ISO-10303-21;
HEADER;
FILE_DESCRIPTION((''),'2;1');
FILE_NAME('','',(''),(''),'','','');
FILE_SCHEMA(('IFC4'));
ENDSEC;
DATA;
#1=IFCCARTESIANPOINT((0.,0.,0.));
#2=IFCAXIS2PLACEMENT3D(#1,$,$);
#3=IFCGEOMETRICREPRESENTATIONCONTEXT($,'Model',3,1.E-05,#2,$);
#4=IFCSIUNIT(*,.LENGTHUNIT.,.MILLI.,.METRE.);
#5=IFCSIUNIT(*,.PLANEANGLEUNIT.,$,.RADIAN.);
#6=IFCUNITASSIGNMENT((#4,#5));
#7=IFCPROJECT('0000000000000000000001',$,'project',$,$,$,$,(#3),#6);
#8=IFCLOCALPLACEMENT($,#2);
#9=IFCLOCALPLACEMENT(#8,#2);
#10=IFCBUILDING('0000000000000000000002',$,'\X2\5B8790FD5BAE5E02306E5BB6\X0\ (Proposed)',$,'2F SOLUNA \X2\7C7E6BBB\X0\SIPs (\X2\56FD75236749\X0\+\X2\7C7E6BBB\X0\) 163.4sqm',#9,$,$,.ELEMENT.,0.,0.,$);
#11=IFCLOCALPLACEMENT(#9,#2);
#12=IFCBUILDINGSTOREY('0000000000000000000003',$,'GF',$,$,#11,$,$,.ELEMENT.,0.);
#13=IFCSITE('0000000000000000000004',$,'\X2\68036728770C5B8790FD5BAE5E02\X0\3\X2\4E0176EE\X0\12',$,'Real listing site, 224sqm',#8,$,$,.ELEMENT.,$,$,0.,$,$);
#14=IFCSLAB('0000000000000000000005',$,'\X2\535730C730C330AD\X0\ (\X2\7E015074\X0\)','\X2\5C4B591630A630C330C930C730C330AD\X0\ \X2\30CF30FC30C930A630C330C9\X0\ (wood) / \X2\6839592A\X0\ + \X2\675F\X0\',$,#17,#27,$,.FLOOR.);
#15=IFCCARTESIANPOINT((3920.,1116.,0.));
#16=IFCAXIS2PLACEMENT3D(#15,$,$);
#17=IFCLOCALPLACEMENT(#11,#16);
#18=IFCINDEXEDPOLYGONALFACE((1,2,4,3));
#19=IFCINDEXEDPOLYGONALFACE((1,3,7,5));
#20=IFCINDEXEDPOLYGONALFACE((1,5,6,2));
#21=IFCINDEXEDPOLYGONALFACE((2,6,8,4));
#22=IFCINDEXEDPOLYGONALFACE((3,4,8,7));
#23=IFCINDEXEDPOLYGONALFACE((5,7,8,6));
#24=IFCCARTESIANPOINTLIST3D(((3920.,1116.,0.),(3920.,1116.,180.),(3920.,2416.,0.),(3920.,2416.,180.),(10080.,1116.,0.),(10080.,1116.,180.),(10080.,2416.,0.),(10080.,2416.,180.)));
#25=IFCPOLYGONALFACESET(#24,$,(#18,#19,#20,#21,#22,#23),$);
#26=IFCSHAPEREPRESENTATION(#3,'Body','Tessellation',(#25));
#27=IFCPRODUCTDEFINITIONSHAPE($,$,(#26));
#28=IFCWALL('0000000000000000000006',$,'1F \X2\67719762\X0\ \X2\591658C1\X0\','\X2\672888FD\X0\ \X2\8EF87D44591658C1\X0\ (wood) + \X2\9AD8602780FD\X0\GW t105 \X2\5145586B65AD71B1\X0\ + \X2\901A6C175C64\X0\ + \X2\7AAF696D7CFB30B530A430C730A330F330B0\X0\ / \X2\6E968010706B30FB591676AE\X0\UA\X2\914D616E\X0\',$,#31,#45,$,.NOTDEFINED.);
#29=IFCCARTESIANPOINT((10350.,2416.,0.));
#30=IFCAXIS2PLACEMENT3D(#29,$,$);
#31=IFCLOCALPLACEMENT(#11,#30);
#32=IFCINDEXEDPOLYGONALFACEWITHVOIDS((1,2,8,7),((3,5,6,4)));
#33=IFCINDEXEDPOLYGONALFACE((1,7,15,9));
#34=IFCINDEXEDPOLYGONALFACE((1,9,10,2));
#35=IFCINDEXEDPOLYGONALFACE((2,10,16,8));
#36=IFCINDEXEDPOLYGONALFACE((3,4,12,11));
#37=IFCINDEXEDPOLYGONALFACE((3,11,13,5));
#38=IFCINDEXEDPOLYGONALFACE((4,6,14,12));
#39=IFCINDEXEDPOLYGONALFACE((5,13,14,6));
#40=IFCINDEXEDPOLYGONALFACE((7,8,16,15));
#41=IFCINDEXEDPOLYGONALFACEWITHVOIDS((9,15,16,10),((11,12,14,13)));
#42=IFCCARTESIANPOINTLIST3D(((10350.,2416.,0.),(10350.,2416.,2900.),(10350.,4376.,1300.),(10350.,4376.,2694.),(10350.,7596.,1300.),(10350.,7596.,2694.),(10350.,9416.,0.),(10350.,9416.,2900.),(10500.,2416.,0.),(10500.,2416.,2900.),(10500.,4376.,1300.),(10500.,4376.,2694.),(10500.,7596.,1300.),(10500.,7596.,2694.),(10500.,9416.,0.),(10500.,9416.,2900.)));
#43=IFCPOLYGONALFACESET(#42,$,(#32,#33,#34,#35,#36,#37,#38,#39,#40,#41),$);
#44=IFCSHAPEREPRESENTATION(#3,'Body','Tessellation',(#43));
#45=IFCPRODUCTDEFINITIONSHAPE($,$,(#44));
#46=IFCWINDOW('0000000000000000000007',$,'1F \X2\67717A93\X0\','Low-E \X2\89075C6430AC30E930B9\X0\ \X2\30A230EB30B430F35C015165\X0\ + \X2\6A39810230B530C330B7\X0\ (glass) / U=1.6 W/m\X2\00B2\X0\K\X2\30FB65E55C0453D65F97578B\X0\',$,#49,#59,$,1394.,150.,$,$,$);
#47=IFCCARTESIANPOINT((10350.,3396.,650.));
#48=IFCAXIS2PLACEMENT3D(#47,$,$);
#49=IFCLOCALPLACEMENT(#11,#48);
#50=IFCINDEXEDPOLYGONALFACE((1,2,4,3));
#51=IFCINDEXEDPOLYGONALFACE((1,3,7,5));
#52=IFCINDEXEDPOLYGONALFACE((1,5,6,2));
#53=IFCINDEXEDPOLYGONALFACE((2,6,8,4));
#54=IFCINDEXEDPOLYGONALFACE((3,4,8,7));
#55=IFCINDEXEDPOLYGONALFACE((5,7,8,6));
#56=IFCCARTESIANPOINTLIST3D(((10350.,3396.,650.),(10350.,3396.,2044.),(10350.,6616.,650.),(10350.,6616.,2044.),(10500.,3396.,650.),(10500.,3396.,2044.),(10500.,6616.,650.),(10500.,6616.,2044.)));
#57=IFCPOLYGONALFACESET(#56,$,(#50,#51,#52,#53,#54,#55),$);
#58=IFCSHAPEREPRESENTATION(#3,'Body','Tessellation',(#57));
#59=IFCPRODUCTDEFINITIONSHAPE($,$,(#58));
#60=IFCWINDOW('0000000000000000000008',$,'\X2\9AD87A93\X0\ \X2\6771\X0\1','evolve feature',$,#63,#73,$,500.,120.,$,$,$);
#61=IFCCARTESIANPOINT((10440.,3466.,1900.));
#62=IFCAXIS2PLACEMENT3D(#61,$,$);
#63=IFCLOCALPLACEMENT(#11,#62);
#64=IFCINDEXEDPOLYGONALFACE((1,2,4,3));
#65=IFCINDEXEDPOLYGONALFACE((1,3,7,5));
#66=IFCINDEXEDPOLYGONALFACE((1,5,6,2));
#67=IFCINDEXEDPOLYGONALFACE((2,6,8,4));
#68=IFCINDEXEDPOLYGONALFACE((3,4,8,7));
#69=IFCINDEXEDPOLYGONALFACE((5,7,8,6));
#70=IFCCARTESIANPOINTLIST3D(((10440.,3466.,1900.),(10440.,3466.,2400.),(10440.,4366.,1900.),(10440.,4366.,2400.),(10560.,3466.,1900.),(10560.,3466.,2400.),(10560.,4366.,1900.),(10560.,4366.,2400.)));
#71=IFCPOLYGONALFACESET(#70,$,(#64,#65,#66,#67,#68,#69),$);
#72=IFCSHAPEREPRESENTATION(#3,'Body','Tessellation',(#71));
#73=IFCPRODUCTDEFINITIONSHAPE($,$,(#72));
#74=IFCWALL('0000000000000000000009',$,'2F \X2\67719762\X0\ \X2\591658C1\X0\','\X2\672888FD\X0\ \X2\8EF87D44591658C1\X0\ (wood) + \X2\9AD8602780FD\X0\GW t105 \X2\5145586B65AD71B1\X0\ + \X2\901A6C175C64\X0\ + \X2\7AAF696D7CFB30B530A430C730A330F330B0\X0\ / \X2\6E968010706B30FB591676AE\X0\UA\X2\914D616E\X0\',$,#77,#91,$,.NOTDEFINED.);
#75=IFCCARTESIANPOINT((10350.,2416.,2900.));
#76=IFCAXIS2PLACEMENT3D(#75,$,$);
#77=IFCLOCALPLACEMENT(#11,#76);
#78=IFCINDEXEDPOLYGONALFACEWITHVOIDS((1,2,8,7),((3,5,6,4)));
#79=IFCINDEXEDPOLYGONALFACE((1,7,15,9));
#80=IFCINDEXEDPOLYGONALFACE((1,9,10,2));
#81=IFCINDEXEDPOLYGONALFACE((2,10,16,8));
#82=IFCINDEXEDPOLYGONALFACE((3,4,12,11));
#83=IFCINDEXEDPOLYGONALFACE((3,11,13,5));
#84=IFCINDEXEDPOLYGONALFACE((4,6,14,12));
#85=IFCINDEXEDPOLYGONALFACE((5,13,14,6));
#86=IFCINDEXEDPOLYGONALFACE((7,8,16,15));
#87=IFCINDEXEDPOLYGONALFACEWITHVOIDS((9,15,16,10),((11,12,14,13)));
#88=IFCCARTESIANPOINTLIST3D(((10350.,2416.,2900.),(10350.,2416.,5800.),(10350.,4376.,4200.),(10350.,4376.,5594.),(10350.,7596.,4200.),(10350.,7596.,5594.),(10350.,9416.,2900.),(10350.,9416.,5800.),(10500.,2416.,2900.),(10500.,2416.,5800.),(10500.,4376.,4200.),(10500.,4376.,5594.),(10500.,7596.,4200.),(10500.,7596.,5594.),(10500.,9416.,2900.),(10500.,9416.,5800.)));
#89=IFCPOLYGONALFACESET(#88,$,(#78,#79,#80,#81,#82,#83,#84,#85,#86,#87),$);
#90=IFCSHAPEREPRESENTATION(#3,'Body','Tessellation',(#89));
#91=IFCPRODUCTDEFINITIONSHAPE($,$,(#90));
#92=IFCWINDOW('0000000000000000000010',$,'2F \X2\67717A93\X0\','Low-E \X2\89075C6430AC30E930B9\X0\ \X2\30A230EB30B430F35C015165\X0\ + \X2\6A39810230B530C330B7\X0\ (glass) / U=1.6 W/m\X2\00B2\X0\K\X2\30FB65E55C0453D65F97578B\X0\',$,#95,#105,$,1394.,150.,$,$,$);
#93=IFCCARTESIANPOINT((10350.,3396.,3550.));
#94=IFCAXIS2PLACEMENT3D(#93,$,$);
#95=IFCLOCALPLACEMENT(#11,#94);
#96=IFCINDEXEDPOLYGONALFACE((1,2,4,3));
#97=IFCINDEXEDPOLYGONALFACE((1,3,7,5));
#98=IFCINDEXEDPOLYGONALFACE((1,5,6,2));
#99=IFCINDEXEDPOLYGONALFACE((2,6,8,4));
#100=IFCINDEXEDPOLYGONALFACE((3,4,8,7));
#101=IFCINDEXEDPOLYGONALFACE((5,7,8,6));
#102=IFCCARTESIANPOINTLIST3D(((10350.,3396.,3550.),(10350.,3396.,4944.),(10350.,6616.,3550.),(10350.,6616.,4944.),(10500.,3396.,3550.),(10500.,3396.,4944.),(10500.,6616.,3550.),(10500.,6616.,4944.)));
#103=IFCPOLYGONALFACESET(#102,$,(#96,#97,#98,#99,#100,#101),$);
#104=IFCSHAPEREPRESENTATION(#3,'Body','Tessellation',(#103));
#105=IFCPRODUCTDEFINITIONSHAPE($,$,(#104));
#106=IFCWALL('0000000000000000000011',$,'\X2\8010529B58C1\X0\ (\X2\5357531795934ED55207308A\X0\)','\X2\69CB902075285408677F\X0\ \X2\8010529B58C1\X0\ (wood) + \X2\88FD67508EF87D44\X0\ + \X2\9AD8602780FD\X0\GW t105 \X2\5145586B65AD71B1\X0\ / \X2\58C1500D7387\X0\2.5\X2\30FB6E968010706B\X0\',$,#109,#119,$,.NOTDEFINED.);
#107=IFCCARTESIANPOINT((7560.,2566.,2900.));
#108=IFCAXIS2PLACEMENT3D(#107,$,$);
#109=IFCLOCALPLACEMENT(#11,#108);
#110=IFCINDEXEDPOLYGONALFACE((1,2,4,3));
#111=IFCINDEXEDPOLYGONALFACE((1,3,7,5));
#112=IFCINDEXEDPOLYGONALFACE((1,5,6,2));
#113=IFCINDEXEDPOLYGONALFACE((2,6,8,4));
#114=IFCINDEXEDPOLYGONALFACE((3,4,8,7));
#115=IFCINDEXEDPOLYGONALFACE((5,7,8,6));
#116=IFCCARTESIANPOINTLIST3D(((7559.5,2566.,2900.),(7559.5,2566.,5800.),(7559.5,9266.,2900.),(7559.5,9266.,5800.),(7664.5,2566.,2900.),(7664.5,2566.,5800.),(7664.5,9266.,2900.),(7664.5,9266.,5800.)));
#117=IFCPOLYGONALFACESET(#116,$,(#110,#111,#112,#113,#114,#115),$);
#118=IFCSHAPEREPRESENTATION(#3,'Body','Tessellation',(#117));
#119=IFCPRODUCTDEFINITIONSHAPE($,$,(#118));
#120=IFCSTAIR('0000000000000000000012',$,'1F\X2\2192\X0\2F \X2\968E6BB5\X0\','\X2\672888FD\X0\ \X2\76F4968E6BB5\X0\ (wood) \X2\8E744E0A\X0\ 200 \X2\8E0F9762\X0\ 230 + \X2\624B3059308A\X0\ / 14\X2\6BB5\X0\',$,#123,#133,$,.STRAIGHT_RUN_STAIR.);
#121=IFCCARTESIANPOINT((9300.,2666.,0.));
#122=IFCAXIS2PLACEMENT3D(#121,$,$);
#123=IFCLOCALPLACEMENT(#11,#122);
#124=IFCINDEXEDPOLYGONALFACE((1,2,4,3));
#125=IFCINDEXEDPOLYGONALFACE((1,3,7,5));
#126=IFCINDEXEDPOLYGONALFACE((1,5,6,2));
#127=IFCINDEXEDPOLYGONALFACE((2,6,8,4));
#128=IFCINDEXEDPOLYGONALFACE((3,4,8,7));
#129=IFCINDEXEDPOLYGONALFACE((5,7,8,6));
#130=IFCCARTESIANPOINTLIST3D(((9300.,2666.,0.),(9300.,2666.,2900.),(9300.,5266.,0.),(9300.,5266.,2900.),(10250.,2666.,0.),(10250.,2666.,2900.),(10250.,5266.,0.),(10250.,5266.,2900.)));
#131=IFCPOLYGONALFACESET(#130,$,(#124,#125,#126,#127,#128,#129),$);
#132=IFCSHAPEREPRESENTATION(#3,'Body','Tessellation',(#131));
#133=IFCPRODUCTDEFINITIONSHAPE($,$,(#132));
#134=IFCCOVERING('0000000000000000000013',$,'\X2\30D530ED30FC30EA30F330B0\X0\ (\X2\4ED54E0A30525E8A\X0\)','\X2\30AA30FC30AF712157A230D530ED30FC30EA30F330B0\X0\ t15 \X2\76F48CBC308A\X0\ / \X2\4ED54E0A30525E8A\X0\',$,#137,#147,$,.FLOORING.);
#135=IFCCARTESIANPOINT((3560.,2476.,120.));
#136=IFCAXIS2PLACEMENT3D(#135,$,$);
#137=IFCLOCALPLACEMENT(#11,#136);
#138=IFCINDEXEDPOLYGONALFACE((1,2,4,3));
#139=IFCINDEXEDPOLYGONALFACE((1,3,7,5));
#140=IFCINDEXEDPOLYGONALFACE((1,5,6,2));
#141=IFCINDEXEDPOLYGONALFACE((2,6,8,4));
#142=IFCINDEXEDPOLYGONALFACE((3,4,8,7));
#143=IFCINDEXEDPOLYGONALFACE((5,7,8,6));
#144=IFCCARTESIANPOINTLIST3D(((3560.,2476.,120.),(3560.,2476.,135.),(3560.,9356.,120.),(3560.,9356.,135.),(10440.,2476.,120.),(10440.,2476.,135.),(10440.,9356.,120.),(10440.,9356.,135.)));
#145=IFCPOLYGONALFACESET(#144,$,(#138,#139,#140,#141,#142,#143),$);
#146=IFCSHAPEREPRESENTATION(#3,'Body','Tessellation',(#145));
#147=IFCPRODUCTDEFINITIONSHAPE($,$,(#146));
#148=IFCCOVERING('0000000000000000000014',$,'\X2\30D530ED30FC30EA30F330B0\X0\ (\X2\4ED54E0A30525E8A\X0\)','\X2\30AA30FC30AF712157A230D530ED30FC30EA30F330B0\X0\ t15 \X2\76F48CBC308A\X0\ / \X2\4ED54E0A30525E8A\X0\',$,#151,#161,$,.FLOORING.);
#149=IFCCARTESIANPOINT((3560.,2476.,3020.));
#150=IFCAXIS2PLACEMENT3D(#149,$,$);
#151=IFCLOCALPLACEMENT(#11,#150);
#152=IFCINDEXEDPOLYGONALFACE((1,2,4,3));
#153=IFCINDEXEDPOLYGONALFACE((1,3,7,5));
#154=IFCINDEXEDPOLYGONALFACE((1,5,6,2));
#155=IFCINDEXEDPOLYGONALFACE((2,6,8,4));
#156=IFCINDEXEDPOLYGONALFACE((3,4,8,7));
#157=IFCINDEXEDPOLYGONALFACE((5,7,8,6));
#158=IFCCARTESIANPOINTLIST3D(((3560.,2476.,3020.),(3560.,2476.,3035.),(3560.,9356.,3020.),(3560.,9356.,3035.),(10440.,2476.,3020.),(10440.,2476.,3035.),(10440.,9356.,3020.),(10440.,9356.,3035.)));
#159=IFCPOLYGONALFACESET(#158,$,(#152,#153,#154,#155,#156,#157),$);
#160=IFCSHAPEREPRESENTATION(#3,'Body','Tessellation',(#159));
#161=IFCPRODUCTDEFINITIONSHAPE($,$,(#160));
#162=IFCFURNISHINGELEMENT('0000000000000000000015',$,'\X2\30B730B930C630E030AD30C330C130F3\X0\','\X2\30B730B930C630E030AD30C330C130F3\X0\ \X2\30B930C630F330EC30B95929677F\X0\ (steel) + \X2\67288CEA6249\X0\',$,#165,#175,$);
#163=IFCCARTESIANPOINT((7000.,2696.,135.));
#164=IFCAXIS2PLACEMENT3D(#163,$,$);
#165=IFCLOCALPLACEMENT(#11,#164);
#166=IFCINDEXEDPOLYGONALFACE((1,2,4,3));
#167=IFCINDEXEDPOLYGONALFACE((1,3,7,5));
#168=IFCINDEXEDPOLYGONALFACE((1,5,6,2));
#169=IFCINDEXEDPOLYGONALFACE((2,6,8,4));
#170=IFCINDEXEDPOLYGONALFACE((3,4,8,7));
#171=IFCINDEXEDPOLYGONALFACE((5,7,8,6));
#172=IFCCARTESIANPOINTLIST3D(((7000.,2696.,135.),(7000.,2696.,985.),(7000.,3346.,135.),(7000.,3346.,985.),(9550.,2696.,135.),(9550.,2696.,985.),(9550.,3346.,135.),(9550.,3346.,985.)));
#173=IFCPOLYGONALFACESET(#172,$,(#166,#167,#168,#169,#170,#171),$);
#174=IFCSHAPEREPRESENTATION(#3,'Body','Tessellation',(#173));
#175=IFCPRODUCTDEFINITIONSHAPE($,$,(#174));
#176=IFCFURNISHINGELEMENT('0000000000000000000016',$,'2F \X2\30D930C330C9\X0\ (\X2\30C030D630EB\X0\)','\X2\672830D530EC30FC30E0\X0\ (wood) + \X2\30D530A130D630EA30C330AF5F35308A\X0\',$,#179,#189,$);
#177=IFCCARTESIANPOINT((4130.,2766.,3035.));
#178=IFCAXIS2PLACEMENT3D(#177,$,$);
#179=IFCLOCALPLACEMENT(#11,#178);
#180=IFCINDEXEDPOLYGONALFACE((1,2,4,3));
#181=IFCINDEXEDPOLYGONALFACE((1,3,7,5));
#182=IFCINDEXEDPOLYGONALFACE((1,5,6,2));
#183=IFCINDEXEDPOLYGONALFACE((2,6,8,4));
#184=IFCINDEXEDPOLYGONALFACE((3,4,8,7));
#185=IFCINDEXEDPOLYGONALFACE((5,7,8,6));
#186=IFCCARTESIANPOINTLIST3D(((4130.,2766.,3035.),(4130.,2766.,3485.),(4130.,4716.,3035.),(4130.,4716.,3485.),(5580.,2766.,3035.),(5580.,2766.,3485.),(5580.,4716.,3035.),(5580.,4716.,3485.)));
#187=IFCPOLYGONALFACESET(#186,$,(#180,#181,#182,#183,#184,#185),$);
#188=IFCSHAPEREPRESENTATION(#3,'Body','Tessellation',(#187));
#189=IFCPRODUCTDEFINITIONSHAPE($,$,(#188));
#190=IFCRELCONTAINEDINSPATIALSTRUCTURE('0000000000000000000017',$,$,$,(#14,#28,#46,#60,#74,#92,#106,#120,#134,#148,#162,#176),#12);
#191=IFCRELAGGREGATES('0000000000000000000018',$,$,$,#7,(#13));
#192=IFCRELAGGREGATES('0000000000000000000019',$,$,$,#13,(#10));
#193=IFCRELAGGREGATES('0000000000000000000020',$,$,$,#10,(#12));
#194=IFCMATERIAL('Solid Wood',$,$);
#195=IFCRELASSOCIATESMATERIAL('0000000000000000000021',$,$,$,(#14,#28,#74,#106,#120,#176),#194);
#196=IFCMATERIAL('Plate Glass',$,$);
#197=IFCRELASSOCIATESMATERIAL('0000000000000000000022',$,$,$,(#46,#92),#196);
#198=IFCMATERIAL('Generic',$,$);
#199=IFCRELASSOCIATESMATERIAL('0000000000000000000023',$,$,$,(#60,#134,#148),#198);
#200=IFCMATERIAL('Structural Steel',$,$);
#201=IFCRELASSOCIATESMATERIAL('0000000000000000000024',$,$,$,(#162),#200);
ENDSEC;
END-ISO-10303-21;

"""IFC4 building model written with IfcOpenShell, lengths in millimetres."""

from ifc_helpers import new_model, si_unit, frame, frame_2d, origin, place, context, project, spatial, rectangle, extrude, material, element, fill, save


model = new_model("IFC4")

# Units and contexts
model_context = context("Model", 3, precision=1e-05, world=origin())
ifc_project = project(units=[si_unit("LENGTHUNIT", "METRE", prefix="MILLI"), si_unit("PLANEANGLEUNIT", "RADIAN")], contexts=[model_context])

# Site, building, storey
site_placement = place(None, origin())
site = spatial("IfcSite", under=ifc_project, at=site_placement, Name="栃木県宇都宮市3丁目12", ObjectType="Real listing site, 224sqm", CompositionType="ELEMENT", RefElevation=0.0)
building_placement = place(site_placement, origin())
building = spatial("IfcBuilding", under=site, at=building_placement, Name="宇都宮市の家 (Proposed)", ObjectType="2F SOLUNA 籾殻SIPs (国産杉+籾殻) 163.4sqm", CompositionType="ELEMENT", ElevationOfRefHeight=0.0, ElevationOfTerrain=0.0)
storey_placement = place(building_placement, origin())
storey = spatial("IfcBuildingStorey", under=building, at=storey_placement, Name="GF", CompositionType="ELEMENT", Elevation=0.0)

# Slab
ifc_material_1 = material(Name="Solid Wood")
slab_placement = place(storey_placement, frame((3920.0, 1116.0, 0.0)))
element("IfcSlab", 1, at=slab_placement, inside=storey, material=ifc_material_1, Name="南デッキ (縁側)", Description="屋外ウッドデッキ ハードウッド (wood) / 根太 + 束", PredefinedType="FLOOR", context=model_context, shape_type="SweptSolid", body=[
    extrude(rectangle(XDim=6160.0, YDim=1300.0, at=frame_2d((3080.0, 650.0))), frame((3920.0, 1116.0, 0.0)), (0.0, 0.0, 1.0), 180.0),
])

# Wall, openings, windows
wall_1_placement = place(storey_placement, frame((10350.0, 2416.0, 0.0)))
wall_1 = element("IfcWall", 2, at=wall_1_placement, inside=storey, material=ifc_material_1, Name="1F 東面 外壁", Description="木製 軸組外壁 (wood) + 高性能GW t105 充填断熱 + 通気層 + 窯業系サイディング / 準耐火・外皮UA配慮", PredefinedType="NOTDEFINED", context=model_context, shape_type="SweptSolid", body=[
    extrude(rectangle(XDim=150.0, YDim=7000.0, at=frame_2d((75.0, 3500.0))), frame((10350.0, 2416.0, 0.0)), (0.0, 0.0, 1.0), 2900.0),
])
opening_1_placement = place(storey_placement, frame((10350.0, 3396.0, 650.0)))
opening_1 = element("IfcOpeningElement", 3, at=opening_1_placement, cuts=wall_1, PredefinedType="NOTDEFINED", context=model_context, shape_type="SweptSolid", body=[
    extrude(rectangle(XDim=150.0, YDim=3220.0, at=frame_2d((75.0, 1610.0))), frame((10350.0, 3396.0, 650.0)), (0.0, 0.0, 1.0), 1394.0),
])
opening_2_placement = place(storey_placement, frame((10440.0, 3466.0, 1900.0)))
opening_2 = element("IfcOpeningElement", 4, at=opening_2_placement, cuts=wall_1, PredefinedType="NOTDEFINED", context=model_context, shape_type="SweptSolid", body=[
    extrude(rectangle(XDim=120.0, YDim=900.0, at=frame_2d((60.0, 450.0))), frame((10440.0, 3466.0, 1900.0)), (0.0, 0.0, 1.0), 500.0),
])
ifc_material_2 = material(Name="Plate Glass")
window_1_placement = place(storey_placement, frame((10350.0, 3396.0, 650.0)))
window_1 = element("IfcWindow", 5, at=window_1_placement, inside=storey, material=ifc_material_2, Name="1F 東窓", Description="Low-E 複層ガラス アルゴン封入 + 樹脂サッシ (glass) / U=1.6 W/m²K・日射取得型", OverallHeight=1394.0, OverallWidth=150.0, context=model_context, shape_type="SweptSolid", body=[
    extrude(rectangle(XDim=150.0, YDim=3220.0, at=frame_2d((75.0, 1610.0))), frame((10350.0, 3396.0, 650.0)), (0.0, 0.0, 1.0), 1394.0),
])
fill(opening_1, window_1)
ifc_material_3 = material(Name="Generic")
window_2_placement = place(storey_placement, frame((10440.0, 3466.0, 1900.0)))
window_2 = element("IfcWindow", 6, at=window_2_placement, inside=storey, material=ifc_material_3, Name="高窓 東1", Description="evolve feature", OverallHeight=500.0, OverallWidth=120.0, context=model_context, shape_type="SweptSolid", body=[
    extrude(rectangle(XDim=120.0, YDim=900.0, at=frame_2d((60.0, 450.0))), frame((10440.0, 3466.0, 1900.0)), (0.0, 0.0, 1.0), 500.0),
])
fill(opening_2, window_2)

# Wall, opening, window
wall_2_placement = place(storey_placement, frame((10350.0, 2416.0, 2900.0)))
wall_2 = element("IfcWall", 7, at=wall_2_placement, inside=storey, material=ifc_material_1, Name="2F 東面 外壁", Description="木製 軸組外壁 (wood) + 高性能GW t105 充填断熱 + 通気層 + 窯業系サイディング / 準耐火・外皮UA配慮", PredefinedType="NOTDEFINED", context=model_context, shape_type="SweptSolid", body=[
    extrude(rectangle(XDim=150.0, YDim=7000.0, at=frame_2d((75.0, 3500.0))), frame((10350.0, 2416.0, 2900.0)), (0.0, 0.0, 1.0), 2900.0),
])
opening_3_placement = place(storey_placement, frame((10350.0, 3396.0, 3550.0)))
opening_3 = element("IfcOpeningElement", 8, at=opening_3_placement, cuts=wall_2, PredefinedType="NOTDEFINED", context=model_context, shape_type="SweptSolid", body=[
    extrude(rectangle(XDim=150.0, YDim=3220.0, at=frame_2d((75.0, 1610.0))), frame((10350.0, 3396.0, 3550.0)), (0.0, 0.0, 1.0), 1394.0),
])
window_3_placement = place(storey_placement, frame((10350.0, 3396.0, 3550.0)))
window_3 = element("IfcWindow", 9, at=window_3_placement, inside=storey, material=ifc_material_2, Name="2F 東窓", Description="Low-E 複層ガラス アルゴン封入 + 樹脂サッシ (glass) / U=1.6 W/m²K・日射取得型", OverallHeight=1394.0, OverallWidth=150.0, context=model_context, shape_type="SweptSolid", body=[
    extrude(rectangle(XDim=150.0, YDim=3220.0, at=frame_2d((75.0, 1610.0))), frame((10350.0, 3396.0, 3550.0)), (0.0, 0.0, 1.0), 1394.0),
])
fill(opening_3, window_3)

# Wall
wall_3_placement = place(storey_placement, frame((7560.0, 2566.0, 2900.0)))
element("IfcWall", 10, at=wall_3_placement, inside=storey, material=ifc_material_1, Name="耐力壁 (南北間仕切り)", Description="構造用合板 耐力壁 (wood) + 製材軸組 + 高性能GW t105 充填断熱 / 壁倍率2.5・準耐火", PredefinedType="NOTDEFINED", context=model_context, shape_type="SweptSolid", body=[
    extrude(rectangle(XDim=105.0, YDim=6700.0, at=frame_2d((52.0, 3350.0))), frame((7560.0, 2566.0, 2900.0)), (0.0, 0.0, 1.0), 2900.0),
])

# Stair
stair_placement = place(storey_placement, frame((9300.0, 2666.0, 0.0)))
element("IfcStair", 11, at=stair_placement, inside=storey, material=ifc_material_1, Name="1F→2F 階段", Description="木製 直階段 (wood) 蹴上 200 踏面 230 + 手すり / 14段", PredefinedType="STRAIGHT_RUN_STAIR", context=model_context, shape_type="SweptSolid", body=[
    extrude(rectangle(XDim=950.0, YDim=2600.0, at=frame_2d((475.0, 1300.0))), frame((9300.0, 2666.0, 0.0)), (0.0, 0.0, 1.0), 2900.0),
])

# Coverings
covering_1_placement = place(storey_placement, frame((3560.0, 2476.0, 120.0)))
element("IfcCovering", 12, at=covering_1_placement, inside=storey, material=ifc_material_3, Name="フローリング (仕上げ床)", Description="オーク無垢フローリング t15 直貼り / 仕上げ床", PredefinedType="FLOORING", context=model_context, shape_type="SweptSolid", body=[
    extrude(rectangle(XDim=6880.0, YDim=6880.0, at=frame_2d((3440.0, 3440.0))), frame((3560.0, 2476.0, 120.0)), (0.0, 0.0, 1.0), 15.0),
])
covering_2_placement = place(storey_placement, frame((3560.0, 2476.0, 3020.0)))
element("IfcCovering", 13, at=covering_2_placement, inside=storey, material=ifc_material_3, Name="フローリング (仕上げ床)", Description="オーク無垢フローリング t15 直貼り / 仕上げ床", PredefinedType="FLOORING", context=model_context, shape_type="SweptSolid", body=[
    extrude(rectangle(XDim=6880.0, YDim=6880.0, at=frame_2d((3440.0, 3440.0))), frame((3560.0, 2476.0, 3020.0)), (0.0, 0.0, 1.0), 15.0),
])

# Furnishing elements
ifc_material_4 = material(Name="Structural Steel")
furnishing_1_placement = place(storey_placement, frame((7000.0, 2696.0, 135.0)))
element("IfcFurnishingElement", 14, at=furnishing_1_placement, inside=storey, material=ifc_material_4, Name="システムキッチン", Description="システムキッチン ステンレス天板 (steel) + 木質扉", context=model_context, shape_type="SweptSolid", body=[
    extrude(rectangle(XDim=2550.0, YDim=650.0, at=frame_2d((1275.0, 325.0))), frame((7000.0, 2696.0, 135.0)), (0.0, 0.0, 1.0), 850.0),
])
furnishing_2_placement = place(storey_placement, frame((4130.0, 2766.0, 3035.0)))
element("IfcFurnishingElement", 15, at=furnishing_2_placement, inside=storey, material=ifc_material_1, Name="2F ベッド (ダブル)", Description="木フレーム (wood) + ファブリック張り", context=model_context, shape_type="SweptSolid", body=[
    extrude(rectangle(XDim=1450.0, YDim=1950.0, at=frame_2d((725.0, 975.0))), frame((4130.0, 2766.0, 3035.0)), (0.0, 0.0, 1.0), 450.0),
])

save(model, "model.ifc")
